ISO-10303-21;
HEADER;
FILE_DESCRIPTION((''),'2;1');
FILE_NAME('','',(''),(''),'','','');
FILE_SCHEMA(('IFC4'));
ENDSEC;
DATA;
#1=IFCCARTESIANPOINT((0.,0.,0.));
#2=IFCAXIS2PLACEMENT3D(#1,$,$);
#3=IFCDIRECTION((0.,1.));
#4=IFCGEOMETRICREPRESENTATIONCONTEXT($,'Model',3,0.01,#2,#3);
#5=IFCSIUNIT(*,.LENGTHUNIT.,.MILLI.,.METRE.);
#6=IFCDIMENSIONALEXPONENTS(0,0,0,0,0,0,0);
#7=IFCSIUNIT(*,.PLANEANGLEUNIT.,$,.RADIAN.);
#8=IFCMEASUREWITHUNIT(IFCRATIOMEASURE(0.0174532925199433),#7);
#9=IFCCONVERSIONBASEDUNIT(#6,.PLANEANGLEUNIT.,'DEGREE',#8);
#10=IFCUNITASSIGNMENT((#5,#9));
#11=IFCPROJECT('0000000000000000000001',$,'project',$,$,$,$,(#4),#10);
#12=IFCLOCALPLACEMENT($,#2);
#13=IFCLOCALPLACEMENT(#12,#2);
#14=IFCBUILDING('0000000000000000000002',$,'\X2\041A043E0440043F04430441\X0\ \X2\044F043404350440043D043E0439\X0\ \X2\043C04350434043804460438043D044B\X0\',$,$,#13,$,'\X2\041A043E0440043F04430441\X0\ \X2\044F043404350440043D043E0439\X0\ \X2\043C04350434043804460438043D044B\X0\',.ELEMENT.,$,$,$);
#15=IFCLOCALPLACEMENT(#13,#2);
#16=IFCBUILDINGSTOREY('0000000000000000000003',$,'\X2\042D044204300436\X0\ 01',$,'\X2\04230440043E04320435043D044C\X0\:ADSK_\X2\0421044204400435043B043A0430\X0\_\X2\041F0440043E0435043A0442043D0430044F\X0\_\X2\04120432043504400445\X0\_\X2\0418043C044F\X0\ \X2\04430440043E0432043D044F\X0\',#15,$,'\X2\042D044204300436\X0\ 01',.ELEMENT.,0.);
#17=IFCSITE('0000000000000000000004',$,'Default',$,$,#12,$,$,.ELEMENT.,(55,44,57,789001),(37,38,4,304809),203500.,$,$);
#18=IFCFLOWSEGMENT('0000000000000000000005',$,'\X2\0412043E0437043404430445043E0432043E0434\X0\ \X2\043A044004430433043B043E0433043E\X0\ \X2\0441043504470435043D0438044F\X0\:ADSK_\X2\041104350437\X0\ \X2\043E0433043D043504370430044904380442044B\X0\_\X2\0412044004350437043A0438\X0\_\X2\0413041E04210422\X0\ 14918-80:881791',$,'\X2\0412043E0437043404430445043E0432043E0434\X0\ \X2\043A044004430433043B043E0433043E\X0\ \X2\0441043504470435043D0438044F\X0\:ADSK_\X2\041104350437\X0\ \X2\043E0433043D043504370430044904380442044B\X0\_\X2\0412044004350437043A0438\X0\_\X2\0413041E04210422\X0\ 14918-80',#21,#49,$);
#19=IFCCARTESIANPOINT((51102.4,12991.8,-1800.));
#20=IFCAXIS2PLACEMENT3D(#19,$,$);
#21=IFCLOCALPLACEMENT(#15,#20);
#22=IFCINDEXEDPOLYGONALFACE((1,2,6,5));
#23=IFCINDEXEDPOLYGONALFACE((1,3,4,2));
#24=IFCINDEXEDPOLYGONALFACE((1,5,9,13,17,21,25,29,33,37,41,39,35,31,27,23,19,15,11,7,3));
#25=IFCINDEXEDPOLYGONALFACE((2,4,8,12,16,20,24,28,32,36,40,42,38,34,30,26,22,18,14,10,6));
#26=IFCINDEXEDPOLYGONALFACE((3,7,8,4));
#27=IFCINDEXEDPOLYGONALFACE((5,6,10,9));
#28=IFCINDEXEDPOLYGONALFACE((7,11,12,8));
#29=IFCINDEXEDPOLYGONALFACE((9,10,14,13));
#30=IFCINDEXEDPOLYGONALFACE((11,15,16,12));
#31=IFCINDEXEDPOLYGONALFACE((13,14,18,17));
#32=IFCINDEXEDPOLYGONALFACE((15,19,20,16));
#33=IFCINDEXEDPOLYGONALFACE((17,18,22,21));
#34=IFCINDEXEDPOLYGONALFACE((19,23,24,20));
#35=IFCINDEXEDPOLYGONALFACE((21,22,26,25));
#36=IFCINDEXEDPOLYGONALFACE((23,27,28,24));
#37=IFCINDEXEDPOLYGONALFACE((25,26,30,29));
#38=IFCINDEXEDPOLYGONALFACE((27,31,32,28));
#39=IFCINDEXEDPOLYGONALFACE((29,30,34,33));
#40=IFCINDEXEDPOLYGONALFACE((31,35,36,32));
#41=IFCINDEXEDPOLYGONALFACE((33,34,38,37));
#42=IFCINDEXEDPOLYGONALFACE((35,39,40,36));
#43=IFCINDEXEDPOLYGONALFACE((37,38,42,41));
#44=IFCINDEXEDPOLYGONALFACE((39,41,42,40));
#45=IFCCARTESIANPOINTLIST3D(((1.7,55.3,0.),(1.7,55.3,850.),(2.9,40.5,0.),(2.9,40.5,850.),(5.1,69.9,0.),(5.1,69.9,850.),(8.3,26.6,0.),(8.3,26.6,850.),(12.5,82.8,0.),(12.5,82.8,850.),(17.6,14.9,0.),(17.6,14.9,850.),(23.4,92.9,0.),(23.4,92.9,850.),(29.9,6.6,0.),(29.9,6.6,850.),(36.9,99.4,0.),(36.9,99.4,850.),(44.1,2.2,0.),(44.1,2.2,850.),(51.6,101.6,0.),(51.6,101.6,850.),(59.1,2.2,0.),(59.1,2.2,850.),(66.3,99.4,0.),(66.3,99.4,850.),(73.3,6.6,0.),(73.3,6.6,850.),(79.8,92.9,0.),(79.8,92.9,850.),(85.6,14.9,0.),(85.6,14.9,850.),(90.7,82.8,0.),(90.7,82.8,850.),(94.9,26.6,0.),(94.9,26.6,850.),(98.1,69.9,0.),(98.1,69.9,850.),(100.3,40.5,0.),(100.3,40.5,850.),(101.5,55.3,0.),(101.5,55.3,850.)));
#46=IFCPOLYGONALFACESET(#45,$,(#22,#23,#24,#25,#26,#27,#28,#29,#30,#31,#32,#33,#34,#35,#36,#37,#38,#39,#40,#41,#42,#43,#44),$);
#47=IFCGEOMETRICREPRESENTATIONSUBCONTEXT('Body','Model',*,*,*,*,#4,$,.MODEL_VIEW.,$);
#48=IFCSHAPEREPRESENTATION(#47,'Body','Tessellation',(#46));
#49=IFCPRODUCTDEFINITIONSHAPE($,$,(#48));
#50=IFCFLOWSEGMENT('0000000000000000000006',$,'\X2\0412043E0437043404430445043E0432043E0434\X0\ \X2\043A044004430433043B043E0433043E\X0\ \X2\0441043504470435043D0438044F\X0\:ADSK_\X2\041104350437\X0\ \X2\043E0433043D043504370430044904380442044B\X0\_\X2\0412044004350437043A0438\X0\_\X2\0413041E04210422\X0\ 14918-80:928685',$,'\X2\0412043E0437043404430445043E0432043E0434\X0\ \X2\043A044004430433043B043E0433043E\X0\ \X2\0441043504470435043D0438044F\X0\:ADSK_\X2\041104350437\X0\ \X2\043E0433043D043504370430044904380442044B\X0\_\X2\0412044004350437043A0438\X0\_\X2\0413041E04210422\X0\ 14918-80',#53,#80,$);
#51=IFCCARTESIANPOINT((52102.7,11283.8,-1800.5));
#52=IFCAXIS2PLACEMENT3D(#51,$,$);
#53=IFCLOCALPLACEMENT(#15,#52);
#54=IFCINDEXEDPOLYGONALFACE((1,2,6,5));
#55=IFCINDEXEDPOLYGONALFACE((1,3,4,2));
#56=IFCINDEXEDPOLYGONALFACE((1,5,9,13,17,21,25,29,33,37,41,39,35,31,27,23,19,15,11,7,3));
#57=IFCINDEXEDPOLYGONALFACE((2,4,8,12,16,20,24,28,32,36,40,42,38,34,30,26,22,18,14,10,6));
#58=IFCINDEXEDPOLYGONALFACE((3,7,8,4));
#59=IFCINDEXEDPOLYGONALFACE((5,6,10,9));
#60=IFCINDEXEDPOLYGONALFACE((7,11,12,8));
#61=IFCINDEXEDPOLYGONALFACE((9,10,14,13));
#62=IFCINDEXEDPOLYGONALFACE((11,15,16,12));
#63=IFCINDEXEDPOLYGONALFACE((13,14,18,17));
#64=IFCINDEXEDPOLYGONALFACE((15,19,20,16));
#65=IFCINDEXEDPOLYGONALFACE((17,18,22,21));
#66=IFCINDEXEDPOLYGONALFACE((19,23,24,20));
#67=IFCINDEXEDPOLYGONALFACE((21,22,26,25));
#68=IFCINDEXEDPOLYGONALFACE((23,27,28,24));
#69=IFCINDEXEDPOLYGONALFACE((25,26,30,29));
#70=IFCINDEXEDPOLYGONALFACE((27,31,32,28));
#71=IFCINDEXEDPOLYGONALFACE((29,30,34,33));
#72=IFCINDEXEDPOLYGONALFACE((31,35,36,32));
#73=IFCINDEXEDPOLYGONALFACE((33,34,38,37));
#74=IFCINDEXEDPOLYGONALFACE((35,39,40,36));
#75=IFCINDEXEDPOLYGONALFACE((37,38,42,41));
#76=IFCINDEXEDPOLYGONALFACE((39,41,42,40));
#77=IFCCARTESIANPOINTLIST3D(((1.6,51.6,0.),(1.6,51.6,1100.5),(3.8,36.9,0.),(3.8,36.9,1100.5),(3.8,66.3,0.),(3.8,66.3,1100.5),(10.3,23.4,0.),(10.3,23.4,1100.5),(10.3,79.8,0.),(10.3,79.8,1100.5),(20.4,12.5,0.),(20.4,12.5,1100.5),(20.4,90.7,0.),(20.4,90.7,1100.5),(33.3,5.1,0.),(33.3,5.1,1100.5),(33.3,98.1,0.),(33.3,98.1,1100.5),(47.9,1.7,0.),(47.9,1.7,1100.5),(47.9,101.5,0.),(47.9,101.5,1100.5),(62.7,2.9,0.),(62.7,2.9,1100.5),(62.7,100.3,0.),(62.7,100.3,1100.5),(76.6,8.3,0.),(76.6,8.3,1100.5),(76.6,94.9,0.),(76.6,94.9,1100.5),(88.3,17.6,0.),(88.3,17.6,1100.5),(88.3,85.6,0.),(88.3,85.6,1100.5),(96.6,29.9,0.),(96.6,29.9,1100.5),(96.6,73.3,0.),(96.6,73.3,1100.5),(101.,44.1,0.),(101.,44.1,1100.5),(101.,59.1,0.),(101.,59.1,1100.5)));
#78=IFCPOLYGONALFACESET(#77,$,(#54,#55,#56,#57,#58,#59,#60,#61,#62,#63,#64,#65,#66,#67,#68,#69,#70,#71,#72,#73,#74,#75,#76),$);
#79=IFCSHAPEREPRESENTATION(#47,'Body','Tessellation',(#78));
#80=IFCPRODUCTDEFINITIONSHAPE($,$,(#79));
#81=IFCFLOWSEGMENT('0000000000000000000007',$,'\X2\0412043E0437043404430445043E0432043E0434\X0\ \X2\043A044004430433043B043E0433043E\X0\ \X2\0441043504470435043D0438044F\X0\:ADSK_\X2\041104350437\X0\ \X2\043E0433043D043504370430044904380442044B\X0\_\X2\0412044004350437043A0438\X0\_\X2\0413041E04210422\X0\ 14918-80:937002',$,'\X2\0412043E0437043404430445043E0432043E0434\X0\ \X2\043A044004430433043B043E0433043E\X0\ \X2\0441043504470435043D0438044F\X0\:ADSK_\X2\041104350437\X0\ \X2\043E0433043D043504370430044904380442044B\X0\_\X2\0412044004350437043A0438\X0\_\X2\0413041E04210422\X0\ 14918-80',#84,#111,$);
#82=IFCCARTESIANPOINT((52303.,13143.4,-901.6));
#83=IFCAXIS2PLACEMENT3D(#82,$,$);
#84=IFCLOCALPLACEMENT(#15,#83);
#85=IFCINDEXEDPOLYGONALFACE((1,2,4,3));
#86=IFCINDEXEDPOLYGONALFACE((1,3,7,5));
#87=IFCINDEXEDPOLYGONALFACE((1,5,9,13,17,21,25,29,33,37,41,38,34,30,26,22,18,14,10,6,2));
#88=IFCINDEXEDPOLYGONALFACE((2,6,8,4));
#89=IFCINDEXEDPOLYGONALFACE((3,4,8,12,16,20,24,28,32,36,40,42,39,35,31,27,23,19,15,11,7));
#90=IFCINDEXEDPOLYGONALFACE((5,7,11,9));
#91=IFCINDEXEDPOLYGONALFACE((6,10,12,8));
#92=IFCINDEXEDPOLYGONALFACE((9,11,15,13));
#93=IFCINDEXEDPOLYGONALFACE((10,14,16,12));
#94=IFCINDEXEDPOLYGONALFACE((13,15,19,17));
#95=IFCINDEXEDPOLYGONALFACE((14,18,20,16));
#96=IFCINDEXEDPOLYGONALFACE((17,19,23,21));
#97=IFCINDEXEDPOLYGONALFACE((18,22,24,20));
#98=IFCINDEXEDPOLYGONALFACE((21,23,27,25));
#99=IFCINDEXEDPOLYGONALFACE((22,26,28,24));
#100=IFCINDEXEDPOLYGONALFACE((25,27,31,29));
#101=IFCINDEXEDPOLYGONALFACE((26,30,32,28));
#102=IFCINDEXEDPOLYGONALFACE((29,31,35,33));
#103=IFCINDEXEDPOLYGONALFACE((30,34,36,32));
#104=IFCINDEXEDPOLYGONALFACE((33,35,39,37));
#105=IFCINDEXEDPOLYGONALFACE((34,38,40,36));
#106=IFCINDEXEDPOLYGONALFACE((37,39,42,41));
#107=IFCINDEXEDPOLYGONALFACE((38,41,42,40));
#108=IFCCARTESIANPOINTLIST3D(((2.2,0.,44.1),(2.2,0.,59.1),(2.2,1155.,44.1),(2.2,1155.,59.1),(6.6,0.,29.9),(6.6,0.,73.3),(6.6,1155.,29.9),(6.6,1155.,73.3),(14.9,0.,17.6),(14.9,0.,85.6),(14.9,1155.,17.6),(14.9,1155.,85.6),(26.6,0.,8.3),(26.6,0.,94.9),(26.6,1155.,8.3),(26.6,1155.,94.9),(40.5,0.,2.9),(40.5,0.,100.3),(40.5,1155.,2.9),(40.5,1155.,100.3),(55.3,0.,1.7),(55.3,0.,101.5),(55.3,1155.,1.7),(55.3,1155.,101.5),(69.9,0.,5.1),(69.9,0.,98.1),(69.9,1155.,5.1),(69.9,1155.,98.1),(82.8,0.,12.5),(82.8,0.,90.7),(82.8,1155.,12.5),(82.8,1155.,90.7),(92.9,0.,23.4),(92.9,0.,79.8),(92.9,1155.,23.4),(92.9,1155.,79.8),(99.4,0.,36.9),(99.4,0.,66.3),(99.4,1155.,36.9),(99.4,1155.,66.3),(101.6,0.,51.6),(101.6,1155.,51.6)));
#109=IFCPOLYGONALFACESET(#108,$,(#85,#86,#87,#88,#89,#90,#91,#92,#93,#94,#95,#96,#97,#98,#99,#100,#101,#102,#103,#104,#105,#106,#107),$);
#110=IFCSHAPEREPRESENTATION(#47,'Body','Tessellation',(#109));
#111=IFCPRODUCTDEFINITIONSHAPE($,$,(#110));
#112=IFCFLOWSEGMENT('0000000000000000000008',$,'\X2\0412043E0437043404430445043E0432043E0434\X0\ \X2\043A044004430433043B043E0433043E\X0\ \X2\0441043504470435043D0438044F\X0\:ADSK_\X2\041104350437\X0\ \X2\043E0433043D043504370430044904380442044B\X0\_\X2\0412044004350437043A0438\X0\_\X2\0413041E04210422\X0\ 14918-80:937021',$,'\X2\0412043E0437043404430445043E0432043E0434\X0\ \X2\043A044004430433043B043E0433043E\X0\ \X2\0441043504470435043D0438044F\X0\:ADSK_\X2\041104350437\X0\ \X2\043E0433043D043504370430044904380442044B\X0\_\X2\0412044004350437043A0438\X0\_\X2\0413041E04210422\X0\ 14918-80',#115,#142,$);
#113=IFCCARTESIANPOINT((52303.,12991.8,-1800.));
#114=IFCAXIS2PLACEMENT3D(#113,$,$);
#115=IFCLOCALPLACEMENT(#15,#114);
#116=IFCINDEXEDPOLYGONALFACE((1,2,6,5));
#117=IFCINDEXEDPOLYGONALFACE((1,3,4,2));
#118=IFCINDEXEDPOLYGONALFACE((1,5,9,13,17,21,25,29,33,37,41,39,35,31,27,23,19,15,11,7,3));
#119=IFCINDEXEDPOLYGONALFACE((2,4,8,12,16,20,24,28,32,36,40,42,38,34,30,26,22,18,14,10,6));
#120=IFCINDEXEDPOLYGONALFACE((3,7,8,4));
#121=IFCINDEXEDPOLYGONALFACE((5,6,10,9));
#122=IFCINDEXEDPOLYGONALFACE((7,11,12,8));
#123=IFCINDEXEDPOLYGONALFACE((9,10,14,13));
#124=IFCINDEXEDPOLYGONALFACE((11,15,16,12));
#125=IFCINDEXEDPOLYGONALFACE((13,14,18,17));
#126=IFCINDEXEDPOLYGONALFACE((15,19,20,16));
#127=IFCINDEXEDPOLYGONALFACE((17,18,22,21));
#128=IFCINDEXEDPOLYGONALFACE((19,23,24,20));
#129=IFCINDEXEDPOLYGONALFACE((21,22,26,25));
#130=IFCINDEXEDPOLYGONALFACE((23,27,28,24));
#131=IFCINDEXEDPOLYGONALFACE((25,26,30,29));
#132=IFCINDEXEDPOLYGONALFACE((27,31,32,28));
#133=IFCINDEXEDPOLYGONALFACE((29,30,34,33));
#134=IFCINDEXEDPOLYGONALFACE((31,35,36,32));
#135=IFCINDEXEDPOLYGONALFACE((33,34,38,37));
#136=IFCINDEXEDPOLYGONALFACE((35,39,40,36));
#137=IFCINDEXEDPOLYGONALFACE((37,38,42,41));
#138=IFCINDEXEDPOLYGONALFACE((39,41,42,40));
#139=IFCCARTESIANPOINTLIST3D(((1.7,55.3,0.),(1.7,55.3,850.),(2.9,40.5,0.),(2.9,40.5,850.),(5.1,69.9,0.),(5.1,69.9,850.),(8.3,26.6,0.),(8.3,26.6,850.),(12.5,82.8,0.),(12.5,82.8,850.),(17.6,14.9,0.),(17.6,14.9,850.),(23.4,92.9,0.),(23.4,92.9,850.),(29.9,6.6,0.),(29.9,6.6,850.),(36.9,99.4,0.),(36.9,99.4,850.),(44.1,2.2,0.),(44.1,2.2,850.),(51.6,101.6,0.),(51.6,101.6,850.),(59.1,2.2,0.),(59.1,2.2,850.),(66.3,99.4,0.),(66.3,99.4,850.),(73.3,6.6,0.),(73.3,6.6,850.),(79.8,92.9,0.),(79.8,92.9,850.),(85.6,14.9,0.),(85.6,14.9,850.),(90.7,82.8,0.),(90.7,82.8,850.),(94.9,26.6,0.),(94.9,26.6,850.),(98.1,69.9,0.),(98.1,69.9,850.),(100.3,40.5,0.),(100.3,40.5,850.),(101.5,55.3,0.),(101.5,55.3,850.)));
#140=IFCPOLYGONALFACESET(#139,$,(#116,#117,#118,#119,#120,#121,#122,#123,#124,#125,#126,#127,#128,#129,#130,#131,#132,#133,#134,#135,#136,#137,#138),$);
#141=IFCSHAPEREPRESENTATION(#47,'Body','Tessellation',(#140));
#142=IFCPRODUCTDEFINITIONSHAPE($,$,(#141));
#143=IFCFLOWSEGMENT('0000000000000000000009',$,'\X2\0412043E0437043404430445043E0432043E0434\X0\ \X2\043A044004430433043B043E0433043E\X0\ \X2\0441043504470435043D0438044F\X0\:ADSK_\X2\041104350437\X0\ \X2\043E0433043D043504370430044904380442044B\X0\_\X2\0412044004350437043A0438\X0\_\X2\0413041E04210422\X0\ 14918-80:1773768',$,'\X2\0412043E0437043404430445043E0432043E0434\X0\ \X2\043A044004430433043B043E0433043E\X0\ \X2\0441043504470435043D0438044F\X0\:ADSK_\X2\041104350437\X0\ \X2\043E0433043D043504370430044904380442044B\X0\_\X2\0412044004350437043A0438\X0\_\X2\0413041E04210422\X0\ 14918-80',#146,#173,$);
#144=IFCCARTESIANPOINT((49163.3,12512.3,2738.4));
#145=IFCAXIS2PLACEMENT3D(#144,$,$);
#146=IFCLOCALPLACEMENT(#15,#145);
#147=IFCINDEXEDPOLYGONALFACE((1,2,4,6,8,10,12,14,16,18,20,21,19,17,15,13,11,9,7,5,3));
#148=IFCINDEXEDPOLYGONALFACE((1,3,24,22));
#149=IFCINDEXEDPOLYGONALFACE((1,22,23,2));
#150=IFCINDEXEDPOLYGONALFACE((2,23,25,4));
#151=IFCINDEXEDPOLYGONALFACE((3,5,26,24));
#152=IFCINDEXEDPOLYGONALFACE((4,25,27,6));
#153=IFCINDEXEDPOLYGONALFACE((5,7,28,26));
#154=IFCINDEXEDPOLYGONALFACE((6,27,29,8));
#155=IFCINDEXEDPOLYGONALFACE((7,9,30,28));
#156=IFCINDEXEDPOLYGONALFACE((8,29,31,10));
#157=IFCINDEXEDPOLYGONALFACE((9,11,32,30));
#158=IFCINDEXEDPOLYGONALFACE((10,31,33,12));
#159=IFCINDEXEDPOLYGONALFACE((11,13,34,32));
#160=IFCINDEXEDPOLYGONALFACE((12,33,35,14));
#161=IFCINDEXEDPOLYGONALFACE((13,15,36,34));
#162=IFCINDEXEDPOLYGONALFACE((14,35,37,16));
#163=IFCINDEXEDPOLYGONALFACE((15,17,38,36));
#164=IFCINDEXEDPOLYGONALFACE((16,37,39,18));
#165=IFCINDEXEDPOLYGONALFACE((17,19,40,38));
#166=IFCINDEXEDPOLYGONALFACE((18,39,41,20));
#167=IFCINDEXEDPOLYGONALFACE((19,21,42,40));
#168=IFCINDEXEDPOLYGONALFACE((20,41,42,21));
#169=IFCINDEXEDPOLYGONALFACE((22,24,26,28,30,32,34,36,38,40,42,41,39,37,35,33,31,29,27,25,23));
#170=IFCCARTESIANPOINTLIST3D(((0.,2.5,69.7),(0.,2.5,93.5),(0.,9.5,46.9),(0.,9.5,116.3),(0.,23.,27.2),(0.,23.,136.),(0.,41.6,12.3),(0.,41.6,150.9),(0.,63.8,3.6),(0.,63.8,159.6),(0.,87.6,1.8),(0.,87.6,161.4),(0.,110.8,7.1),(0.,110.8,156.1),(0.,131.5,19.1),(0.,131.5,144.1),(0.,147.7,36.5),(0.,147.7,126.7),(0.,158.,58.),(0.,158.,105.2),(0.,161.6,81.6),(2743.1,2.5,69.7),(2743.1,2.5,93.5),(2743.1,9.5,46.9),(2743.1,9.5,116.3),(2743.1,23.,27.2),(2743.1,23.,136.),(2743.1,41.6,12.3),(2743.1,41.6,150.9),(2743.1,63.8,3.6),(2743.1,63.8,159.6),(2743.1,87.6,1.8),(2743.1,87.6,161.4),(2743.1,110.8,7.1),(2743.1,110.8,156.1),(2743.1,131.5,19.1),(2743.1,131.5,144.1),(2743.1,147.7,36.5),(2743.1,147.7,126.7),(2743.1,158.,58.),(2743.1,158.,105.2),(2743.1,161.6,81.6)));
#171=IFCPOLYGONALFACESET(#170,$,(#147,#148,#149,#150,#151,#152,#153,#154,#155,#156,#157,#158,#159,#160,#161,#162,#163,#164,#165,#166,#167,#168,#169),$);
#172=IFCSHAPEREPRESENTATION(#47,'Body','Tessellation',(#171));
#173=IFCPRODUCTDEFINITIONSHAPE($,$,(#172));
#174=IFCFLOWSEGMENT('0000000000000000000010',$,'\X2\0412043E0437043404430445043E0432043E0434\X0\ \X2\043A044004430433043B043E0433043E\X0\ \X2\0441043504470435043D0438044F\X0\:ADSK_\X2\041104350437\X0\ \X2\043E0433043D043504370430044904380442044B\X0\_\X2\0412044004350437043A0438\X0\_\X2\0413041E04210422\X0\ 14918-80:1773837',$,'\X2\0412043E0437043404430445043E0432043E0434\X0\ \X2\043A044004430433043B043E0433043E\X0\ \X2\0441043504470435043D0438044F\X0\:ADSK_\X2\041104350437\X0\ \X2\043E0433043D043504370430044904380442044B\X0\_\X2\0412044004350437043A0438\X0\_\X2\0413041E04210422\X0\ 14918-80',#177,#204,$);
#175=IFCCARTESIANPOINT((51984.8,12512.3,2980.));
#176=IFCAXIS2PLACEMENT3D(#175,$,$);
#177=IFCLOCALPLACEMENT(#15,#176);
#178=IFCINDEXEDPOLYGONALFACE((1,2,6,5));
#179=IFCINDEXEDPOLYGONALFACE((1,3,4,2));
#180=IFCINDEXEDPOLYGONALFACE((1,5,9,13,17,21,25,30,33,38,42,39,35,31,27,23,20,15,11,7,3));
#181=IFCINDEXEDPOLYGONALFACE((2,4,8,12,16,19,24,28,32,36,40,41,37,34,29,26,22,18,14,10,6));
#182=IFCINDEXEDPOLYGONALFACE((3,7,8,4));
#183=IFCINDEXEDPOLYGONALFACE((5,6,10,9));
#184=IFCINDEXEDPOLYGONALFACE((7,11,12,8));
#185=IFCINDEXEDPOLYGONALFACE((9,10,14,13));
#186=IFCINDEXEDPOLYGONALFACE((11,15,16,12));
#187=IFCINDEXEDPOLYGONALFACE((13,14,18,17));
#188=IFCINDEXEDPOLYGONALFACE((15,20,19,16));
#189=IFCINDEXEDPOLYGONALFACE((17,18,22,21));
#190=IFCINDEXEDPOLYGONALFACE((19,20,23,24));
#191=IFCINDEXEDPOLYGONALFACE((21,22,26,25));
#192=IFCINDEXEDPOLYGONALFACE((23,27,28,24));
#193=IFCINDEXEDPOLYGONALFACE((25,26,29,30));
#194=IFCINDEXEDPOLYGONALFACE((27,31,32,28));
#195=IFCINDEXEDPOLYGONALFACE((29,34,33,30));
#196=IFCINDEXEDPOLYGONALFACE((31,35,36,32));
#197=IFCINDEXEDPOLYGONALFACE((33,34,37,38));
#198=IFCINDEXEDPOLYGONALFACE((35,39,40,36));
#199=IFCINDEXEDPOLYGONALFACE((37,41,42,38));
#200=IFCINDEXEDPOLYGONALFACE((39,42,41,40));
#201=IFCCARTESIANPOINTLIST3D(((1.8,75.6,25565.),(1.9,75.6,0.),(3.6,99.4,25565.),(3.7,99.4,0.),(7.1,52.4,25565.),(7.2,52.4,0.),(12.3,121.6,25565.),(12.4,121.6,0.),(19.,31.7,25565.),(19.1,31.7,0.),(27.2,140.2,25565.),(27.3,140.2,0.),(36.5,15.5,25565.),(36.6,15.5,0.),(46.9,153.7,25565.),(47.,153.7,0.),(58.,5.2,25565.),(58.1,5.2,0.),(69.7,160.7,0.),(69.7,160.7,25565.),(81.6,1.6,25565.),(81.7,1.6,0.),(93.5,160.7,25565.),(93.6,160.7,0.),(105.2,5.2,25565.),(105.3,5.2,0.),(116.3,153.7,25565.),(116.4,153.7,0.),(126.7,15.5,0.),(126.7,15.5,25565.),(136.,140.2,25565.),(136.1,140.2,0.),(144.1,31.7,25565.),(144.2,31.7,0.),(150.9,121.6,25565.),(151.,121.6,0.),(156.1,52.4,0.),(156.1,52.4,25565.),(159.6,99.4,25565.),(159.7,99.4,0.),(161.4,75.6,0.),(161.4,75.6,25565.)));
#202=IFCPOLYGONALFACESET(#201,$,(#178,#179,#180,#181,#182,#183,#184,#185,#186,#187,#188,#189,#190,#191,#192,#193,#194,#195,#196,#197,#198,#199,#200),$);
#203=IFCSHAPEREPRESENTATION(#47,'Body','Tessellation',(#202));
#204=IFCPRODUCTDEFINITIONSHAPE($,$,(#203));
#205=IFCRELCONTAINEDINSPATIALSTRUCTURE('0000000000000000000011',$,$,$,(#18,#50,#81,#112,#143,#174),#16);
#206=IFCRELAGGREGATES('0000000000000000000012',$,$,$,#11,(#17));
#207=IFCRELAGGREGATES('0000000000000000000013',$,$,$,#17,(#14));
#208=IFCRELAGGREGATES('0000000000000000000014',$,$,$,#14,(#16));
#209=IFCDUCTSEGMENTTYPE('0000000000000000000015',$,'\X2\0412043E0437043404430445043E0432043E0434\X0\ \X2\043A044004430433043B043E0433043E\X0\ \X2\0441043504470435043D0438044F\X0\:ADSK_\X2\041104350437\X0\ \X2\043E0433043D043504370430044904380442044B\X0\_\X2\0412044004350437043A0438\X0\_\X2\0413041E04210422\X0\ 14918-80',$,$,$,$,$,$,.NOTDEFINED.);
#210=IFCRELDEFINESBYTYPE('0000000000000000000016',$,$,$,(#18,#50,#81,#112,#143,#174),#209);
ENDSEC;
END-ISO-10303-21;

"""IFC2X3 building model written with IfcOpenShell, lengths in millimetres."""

from ifc_helpers import new_model, entity, si_unit, converted_unit, direction, frame, origin, origin_2d_with_axis, place, context, subcontext, project, spatial, circle, extrude, type_object, element, save


model = new_model("IFC2X3")

# Units and contexts
model_context = context("Model", 3, precision=0.01, world=origin(), true_north=direction((0.0, 1.0)))
body_context = subcontext(model_context, "Body", "Model", "MODEL_VIEW")
ifc_project = project(units=[si_unit("LENGTHUNIT", "METRE", prefix="MILLI"), converted_unit("PLANEANGLEUNIT", "DEGREE", entity("IfcRatioMeasure", 0.0174532925199433), si_unit("PLANEANGLEUNIT", "RADIAN"), dimensions=[0, 0, 0, 0, 0, 0, 0])], contexts=[model_context])

# Site, building, storey
site_placement = place(None, origin())
site = spatial("IfcSite", under=ifc_project, at=site_placement, Name="Default", CompositionType="ELEMENT", RefLatitude=(55, 44, 57, 789001), RefLongitude=(37, 38, 4, 304809), RefElevation=203500.0)
building_placement = place(site_placement, origin())
building = spatial("IfcBuilding", under=site, at=building_placement, Name="Корпус ядерной медицины", LongName="Корпус ядерной медицины", CompositionType="ELEMENT")
storey_placement = place(building_placement, origin())
storey = spatial("IfcBuildingStorey", under=building, at=storey_placement, Name="Этаж 01", ObjectType="Уровень:ADSK_Стрелка_Проектная_Вверх_Имя уровня", LongName="Этаж 01", CompositionType="ELEMENT", Elevation=0.0)

# Flow segments
duct_segment_type_1 = type_object("IfcDuctSegmentType", Name="Воздуховод круглого сечения:ADSK_Без огнезащиты_Врезки_ГОСТ 14918-80", PredefinedType="NOTDEFINED")
flow_segment_1_placement = place(storey_placement, frame((51102.4, 12991.8, -1800.0)))
element("IfcFlowSegment", 1, at=flow_segment_1_placement, inside=storey, type_object=duct_segment_type_1, Name="Воздуховод круглого сечения:ADSK_Без огнезащиты_Врезки_ГОСТ 14918-80:881791", ObjectType="Воздуховод круглого сечения:ADSK_Без огнезащиты_Врезки_ГОСТ 14918-80", context=body_context, shape_type="SweptSolid", body=[
    extrude(circle(Radius=50.0, at=origin_2d_with_axis()), frame((51.6, 51.6, 0.0), z_axis=(0.0, 0.0, 1.0), x_axis=(0.0, 1.0, 0.0)), (0.0, 0.0, 1.0), 850.0),
])
flow_segment_2_placement = place(storey_placement, frame((52102.7, 11283.8, -1800.5)))
element("IfcFlowSegment", 2, at=flow_segment_2_placement, inside=storey, type_object=duct_segment_type_1, Name="Воздуховод круглого сечения:ADSK_Без огнезащиты_Врезки_ГОСТ 14918-80:928685", ObjectType="Воздуховод круглого сечения:ADSK_Без огнезащиты_Врезки_ГОСТ 14918-80", context=body_context, shape_type="SweptSolid", body=[
    extrude(circle(Radius=50.0, at=origin_2d_with_axis()), frame((51.6, 51.6, 0.0), z_axis=(0.0, 0.0, 1.0), x_axis=(-1.0, 0.0, 0.0)), (0.0, 0.0, 1.0), 1100.5),
])
flow_segment_3_placement = place(storey_placement, frame((52303.0, 13143.4, -901.6)))
element("IfcFlowSegment", 3, at=flow_segment_3_placement, inside=storey, type_object=duct_segment_type_1, Name="Воздуховод круглого сечения:ADSK_Без огнезащиты_Врезки_ГОСТ 14918-80:937002", ObjectType="Воздуховод круглого сечения:ADSK_Без огнезащиты_Врезки_ГОСТ 14918-80", context=body_context, shape_type="SweptSolid", body=[
    extrude(circle(Radius=50.0, at=origin_2d_with_axis()), frame((51.6, 0.0, 51.6), z_axis=(0.0, 1.0, 0.0), x_axis=(1.0, 0.0, 0.0)), (0.0, 0.0, 1.0), 1155.0),
])
flow_segment_4_placement = place(storey_placement, frame((52303.0, 12991.8, -1800.0)))
element("IfcFlowSegment", 4, at=flow_segment_4_placement, inside=storey, type_object=duct_segment_type_1, Name="Воздуховод круглого сечения:ADSK_Без огнезащиты_Врезки_ГОСТ 14918-80:937021", ObjectType="Воздуховод круглого сечения:ADSK_Без огнезащиты_Врезки_ГОСТ 14918-80", context=body_context, shape_type="SweptSolid", body=[
    extrude(circle(Radius=50.0, at=origin_2d_with_axis()), frame((51.6, 51.6, 0.0), z_axis=(0.0, 0.0, 1.0), x_axis=(0.0, 1.0, 0.0)), (0.0, 0.0, 1.0), 850.0),
])
flow_segment_5_placement = place(storey_placement, frame((49163.3, 12512.3, 2738.4)))
element("IfcFlowSegment", 5, at=flow_segment_5_placement, inside=storey, type_object=duct_segment_type_1, Name="Воздуховод круглого сечения:ADSK_Без огнезащиты_Врезки_ГОСТ 14918-80:1773768", ObjectType="Воздуховод круглого сечения:ADSK_Без огнезащиты_Врезки_ГОСТ 14918-80", context=body_context, shape_type="SweptSolid", body=[
    extrude(circle(Radius=80.0, at=origin_2d_with_axis()), frame((0.0, 81.6, 81.6), z_axis=(1.0, 0.0, 0.0), x_axis=(0.0, 1.0, 0.0)), (0.0, 0.0, 1.0), 2743.1),
])
flow_segment_6_placement = place(storey_placement, frame((51984.8, 12512.3, 2980.0)))
element("IfcFlowSegment", 6, at=flow_segment_6_placement, inside=storey, type_object=duct_segment_type_1, Name="Воздуховод круглого сечения:ADSK_Без огнезащиты_Врезки_ГОСТ 14918-80:1773837", ObjectType="Воздуховод круглого сечения:ADSK_Без огнезащиты_Врезки_ГОСТ 14918-80", context=body_context, shape_type="SweptSolid", body=[
    extrude(circle(Radius=80.0, at=origin_2d_with_axis()), frame((81.7, 81.6, 0.0), z_axis=(-0.000003, 0.0, 1.0), x_axis=(0.0, -1.0, 0.0)), (0.0, 0.0, 1.0), 25565.0),
])

save(model, "model.ifc")
